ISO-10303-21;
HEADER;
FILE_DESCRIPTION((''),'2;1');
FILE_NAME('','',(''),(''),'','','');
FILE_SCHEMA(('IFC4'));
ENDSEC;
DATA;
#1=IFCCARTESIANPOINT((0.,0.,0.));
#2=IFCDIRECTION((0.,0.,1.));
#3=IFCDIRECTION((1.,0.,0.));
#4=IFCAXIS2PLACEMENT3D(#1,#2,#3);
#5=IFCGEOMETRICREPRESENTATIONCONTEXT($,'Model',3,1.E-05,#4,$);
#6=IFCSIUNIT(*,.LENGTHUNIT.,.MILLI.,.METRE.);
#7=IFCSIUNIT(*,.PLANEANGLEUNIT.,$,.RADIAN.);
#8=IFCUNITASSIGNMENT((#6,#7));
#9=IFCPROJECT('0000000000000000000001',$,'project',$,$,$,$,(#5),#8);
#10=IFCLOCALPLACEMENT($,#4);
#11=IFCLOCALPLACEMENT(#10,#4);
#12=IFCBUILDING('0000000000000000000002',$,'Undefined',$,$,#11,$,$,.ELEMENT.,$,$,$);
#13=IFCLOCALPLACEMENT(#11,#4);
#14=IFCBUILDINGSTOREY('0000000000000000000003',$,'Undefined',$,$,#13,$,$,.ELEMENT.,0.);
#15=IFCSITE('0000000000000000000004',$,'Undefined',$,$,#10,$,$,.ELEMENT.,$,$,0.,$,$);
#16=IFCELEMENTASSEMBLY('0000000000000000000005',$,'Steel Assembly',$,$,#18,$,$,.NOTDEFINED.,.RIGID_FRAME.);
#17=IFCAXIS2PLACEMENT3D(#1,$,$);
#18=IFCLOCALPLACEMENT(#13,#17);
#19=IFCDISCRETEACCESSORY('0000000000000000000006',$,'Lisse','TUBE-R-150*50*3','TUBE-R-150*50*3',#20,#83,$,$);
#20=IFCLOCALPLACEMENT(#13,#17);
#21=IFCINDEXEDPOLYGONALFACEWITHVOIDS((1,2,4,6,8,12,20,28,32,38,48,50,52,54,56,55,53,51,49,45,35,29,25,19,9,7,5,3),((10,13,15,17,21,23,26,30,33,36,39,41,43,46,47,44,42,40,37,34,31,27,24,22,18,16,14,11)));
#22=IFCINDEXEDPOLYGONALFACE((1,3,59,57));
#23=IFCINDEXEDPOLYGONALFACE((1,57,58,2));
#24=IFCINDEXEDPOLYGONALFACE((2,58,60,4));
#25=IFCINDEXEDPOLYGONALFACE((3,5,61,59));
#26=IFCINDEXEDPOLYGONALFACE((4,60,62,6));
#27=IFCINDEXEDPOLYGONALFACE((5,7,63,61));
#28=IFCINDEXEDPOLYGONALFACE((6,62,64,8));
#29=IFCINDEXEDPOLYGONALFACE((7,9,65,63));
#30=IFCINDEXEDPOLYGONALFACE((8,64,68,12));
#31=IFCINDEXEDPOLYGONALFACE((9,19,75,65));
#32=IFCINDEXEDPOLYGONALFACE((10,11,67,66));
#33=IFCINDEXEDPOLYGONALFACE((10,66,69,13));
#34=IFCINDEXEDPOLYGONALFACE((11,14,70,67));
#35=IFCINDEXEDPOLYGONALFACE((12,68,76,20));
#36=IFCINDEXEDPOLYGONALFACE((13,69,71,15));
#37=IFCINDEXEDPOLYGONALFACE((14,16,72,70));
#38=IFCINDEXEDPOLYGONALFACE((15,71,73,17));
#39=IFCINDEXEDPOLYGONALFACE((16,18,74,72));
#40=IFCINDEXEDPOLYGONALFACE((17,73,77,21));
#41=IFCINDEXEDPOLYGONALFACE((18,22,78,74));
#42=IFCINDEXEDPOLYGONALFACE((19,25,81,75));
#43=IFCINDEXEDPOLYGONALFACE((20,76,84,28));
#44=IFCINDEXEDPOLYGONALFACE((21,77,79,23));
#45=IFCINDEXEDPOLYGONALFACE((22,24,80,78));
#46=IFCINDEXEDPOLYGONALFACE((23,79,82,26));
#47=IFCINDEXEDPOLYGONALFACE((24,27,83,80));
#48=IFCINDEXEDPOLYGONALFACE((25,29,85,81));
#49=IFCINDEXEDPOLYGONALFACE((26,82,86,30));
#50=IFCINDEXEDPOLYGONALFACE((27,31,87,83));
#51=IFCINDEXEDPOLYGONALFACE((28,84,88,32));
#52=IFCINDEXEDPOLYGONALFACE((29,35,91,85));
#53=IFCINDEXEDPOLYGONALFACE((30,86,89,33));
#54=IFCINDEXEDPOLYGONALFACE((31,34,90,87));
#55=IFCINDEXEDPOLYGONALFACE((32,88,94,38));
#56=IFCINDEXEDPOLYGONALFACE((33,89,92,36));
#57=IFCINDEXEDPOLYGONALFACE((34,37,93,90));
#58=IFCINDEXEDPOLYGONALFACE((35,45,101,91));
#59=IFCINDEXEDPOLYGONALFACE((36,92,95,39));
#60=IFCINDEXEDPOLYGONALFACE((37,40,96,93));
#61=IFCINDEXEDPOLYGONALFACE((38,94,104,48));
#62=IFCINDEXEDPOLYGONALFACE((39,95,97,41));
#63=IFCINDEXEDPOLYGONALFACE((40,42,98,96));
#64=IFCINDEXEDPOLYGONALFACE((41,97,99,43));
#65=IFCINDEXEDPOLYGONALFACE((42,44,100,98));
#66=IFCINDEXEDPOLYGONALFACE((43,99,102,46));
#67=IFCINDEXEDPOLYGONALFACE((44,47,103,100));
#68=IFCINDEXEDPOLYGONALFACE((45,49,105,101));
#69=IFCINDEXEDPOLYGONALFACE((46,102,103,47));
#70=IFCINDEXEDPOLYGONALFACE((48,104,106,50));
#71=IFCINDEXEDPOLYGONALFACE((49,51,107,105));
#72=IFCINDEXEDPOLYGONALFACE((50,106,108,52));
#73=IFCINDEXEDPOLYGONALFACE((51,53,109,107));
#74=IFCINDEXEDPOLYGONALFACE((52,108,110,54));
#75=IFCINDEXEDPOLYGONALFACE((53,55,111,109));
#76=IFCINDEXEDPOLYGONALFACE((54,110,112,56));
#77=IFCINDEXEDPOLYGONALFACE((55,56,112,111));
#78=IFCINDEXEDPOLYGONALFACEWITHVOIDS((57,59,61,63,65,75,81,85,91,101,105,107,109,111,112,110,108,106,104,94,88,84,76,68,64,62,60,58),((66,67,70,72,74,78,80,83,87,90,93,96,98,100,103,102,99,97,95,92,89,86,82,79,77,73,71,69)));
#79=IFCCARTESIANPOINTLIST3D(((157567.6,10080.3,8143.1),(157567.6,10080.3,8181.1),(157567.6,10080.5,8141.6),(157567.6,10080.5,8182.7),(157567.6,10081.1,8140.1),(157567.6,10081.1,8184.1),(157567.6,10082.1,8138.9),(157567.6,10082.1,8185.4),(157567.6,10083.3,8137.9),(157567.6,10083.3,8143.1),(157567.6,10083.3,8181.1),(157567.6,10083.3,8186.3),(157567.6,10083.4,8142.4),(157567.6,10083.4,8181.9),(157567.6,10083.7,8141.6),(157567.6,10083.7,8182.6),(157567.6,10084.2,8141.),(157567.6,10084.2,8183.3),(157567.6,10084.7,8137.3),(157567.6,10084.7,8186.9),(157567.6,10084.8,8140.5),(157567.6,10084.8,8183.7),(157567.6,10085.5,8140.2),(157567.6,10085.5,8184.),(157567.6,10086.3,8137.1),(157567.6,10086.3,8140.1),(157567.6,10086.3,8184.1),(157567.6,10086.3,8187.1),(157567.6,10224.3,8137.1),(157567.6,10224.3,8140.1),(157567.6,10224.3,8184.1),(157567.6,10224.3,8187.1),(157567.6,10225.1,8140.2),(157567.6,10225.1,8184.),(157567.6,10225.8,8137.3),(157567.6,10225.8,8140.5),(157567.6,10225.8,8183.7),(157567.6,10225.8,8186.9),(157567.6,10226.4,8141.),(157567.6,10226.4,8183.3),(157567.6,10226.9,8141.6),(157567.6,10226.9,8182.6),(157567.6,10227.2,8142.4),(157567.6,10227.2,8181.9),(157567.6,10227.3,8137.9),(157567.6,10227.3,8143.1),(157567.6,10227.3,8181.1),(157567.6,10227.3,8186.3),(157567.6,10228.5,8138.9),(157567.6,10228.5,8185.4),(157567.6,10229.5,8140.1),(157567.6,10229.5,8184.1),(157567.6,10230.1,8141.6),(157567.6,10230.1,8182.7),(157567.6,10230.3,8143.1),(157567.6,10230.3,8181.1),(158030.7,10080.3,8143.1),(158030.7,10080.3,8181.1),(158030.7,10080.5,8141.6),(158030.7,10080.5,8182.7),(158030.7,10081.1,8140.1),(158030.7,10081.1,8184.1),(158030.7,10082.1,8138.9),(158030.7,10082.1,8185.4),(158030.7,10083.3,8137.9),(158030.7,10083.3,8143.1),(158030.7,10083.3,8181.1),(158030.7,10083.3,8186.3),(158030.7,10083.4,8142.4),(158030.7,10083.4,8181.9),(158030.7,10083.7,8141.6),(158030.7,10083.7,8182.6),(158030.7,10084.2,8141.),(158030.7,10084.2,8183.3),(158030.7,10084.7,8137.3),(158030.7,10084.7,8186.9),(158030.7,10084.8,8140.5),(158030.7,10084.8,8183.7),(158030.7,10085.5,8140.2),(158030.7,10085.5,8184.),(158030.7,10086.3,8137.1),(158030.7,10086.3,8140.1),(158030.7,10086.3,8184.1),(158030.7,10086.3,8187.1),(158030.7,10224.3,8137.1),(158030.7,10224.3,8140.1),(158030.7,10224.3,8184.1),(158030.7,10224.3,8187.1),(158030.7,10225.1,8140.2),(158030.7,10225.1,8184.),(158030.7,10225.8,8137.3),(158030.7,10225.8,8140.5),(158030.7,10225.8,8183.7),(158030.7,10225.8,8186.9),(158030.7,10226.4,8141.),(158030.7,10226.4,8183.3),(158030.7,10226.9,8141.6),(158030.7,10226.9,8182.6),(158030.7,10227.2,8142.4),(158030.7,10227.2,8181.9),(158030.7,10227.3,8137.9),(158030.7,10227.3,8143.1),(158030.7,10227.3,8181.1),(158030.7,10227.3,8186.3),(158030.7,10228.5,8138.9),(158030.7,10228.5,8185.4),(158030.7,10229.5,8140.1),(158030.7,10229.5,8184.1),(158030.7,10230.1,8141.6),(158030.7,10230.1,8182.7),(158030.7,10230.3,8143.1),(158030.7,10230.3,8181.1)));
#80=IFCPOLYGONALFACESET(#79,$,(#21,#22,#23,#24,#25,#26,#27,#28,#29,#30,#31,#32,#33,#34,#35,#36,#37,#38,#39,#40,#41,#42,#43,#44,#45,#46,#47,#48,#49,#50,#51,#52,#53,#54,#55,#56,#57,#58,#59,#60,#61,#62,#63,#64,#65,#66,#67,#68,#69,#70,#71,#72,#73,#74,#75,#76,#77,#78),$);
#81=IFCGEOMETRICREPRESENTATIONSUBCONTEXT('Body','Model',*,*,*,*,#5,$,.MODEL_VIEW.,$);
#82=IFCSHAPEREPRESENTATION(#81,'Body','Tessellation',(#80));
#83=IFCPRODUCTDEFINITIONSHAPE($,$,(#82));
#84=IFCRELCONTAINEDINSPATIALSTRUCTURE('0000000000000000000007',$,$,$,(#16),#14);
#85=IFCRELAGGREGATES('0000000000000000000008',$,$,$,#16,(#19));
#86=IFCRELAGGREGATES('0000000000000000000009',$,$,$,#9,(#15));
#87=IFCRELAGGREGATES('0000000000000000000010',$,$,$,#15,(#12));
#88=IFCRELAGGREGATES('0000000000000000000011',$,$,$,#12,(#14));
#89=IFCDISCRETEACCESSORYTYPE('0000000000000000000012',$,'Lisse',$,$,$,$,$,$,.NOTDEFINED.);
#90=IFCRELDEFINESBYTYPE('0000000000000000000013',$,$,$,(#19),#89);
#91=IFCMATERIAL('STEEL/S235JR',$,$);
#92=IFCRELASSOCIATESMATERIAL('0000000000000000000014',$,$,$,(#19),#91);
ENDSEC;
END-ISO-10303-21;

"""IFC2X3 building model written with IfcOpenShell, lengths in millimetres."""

from ifc_helpers import new_model, si_unit, frame, origin_with_axes, origin_2d_with_axis, place, context, subcontext, project, spatial, hollow_rectangle, extrude, material, type_object, element, aggregate, save


model = new_model("IFC2X3")

# Units and contexts
model_context = context("Model", 3, precision=1e-05, world=origin_with_axes())
body_context = subcontext(model_context, "Body", "Model", "MODEL_VIEW")
ifc_project = project(units=[si_unit("LENGTHUNIT", "METRE", prefix="MILLI"), si_unit("PLANEANGLEUNIT", "RADIAN")], contexts=[model_context])

# Site, building, storey
site_placement = place(None, origin_with_axes())
site = spatial("IfcSite", under=ifc_project, at=site_placement, Name="Undefined", CompositionType="ELEMENT", RefElevation=0.0)
building_placement = place(site_placement, origin_with_axes())
building = spatial("IfcBuilding", under=site, at=building_placement, Name="Undefined", CompositionType="ELEMENT")
storey_placement = place(building_placement, origin_with_axes())
storey = spatial("IfcBuildingStorey", under=building, at=storey_placement, Name="Undefined", CompositionType="ELEMENT", Elevation=0.0)

# Element assembly
assembly_1_placement = place(storey_placement, origin_with_axes())
assembly_1 = element("IfcElementAssembly", 1, at=assembly_1_placement, inside=storey, Name="Steel Assembly", AssemblyPlace="NOTDEFINED", PredefinedType="RIGID_FRAME")
ifc_material_1 = material(Name="STEEL/S235JR")

# Shared definitions
discrete_accessory_type_1 = type_object("IfcDiscreteAccessoryType", Name="Lisse")

# Discrete accessory
discrete_accessory_1_placement = place(assembly_1_placement, frame((158030.7, 10155.3, 8162.1), z_axis=(0.0, 1.0, 0.0), x_axis=(-1.0, 0.0, 0.0)))
discrete_accessory_1 = element("IfcDiscreteAccessory", 2, at=discrete_accessory_1_placement, type_object=discrete_accessory_type_1, material=ifc_material_1, Name="Lisse", Description="TUBE-R-150*50*3", ObjectType="TUBE-R-150*50*3", context=body_context, shape_type="SweptSolid", body=[
    extrude(hollow_rectangle(XDim=50.0, YDim=150.0, WallThickness=3.0, InnerFilletRadius=3.0, OuterFilletRadius=6.0, at=origin_2d_with_axis()), frame((463.1, 0.0, 0.0), z_axis=(-1.0, 0.0, 0.0), x_axis=(0.0, -1.0, 0.0)), (0.0, 0.0, 1.0), 463.1),
])
aggregate(assembly_1, [discrete_accessory_1])

save(model, "model.ifc")
